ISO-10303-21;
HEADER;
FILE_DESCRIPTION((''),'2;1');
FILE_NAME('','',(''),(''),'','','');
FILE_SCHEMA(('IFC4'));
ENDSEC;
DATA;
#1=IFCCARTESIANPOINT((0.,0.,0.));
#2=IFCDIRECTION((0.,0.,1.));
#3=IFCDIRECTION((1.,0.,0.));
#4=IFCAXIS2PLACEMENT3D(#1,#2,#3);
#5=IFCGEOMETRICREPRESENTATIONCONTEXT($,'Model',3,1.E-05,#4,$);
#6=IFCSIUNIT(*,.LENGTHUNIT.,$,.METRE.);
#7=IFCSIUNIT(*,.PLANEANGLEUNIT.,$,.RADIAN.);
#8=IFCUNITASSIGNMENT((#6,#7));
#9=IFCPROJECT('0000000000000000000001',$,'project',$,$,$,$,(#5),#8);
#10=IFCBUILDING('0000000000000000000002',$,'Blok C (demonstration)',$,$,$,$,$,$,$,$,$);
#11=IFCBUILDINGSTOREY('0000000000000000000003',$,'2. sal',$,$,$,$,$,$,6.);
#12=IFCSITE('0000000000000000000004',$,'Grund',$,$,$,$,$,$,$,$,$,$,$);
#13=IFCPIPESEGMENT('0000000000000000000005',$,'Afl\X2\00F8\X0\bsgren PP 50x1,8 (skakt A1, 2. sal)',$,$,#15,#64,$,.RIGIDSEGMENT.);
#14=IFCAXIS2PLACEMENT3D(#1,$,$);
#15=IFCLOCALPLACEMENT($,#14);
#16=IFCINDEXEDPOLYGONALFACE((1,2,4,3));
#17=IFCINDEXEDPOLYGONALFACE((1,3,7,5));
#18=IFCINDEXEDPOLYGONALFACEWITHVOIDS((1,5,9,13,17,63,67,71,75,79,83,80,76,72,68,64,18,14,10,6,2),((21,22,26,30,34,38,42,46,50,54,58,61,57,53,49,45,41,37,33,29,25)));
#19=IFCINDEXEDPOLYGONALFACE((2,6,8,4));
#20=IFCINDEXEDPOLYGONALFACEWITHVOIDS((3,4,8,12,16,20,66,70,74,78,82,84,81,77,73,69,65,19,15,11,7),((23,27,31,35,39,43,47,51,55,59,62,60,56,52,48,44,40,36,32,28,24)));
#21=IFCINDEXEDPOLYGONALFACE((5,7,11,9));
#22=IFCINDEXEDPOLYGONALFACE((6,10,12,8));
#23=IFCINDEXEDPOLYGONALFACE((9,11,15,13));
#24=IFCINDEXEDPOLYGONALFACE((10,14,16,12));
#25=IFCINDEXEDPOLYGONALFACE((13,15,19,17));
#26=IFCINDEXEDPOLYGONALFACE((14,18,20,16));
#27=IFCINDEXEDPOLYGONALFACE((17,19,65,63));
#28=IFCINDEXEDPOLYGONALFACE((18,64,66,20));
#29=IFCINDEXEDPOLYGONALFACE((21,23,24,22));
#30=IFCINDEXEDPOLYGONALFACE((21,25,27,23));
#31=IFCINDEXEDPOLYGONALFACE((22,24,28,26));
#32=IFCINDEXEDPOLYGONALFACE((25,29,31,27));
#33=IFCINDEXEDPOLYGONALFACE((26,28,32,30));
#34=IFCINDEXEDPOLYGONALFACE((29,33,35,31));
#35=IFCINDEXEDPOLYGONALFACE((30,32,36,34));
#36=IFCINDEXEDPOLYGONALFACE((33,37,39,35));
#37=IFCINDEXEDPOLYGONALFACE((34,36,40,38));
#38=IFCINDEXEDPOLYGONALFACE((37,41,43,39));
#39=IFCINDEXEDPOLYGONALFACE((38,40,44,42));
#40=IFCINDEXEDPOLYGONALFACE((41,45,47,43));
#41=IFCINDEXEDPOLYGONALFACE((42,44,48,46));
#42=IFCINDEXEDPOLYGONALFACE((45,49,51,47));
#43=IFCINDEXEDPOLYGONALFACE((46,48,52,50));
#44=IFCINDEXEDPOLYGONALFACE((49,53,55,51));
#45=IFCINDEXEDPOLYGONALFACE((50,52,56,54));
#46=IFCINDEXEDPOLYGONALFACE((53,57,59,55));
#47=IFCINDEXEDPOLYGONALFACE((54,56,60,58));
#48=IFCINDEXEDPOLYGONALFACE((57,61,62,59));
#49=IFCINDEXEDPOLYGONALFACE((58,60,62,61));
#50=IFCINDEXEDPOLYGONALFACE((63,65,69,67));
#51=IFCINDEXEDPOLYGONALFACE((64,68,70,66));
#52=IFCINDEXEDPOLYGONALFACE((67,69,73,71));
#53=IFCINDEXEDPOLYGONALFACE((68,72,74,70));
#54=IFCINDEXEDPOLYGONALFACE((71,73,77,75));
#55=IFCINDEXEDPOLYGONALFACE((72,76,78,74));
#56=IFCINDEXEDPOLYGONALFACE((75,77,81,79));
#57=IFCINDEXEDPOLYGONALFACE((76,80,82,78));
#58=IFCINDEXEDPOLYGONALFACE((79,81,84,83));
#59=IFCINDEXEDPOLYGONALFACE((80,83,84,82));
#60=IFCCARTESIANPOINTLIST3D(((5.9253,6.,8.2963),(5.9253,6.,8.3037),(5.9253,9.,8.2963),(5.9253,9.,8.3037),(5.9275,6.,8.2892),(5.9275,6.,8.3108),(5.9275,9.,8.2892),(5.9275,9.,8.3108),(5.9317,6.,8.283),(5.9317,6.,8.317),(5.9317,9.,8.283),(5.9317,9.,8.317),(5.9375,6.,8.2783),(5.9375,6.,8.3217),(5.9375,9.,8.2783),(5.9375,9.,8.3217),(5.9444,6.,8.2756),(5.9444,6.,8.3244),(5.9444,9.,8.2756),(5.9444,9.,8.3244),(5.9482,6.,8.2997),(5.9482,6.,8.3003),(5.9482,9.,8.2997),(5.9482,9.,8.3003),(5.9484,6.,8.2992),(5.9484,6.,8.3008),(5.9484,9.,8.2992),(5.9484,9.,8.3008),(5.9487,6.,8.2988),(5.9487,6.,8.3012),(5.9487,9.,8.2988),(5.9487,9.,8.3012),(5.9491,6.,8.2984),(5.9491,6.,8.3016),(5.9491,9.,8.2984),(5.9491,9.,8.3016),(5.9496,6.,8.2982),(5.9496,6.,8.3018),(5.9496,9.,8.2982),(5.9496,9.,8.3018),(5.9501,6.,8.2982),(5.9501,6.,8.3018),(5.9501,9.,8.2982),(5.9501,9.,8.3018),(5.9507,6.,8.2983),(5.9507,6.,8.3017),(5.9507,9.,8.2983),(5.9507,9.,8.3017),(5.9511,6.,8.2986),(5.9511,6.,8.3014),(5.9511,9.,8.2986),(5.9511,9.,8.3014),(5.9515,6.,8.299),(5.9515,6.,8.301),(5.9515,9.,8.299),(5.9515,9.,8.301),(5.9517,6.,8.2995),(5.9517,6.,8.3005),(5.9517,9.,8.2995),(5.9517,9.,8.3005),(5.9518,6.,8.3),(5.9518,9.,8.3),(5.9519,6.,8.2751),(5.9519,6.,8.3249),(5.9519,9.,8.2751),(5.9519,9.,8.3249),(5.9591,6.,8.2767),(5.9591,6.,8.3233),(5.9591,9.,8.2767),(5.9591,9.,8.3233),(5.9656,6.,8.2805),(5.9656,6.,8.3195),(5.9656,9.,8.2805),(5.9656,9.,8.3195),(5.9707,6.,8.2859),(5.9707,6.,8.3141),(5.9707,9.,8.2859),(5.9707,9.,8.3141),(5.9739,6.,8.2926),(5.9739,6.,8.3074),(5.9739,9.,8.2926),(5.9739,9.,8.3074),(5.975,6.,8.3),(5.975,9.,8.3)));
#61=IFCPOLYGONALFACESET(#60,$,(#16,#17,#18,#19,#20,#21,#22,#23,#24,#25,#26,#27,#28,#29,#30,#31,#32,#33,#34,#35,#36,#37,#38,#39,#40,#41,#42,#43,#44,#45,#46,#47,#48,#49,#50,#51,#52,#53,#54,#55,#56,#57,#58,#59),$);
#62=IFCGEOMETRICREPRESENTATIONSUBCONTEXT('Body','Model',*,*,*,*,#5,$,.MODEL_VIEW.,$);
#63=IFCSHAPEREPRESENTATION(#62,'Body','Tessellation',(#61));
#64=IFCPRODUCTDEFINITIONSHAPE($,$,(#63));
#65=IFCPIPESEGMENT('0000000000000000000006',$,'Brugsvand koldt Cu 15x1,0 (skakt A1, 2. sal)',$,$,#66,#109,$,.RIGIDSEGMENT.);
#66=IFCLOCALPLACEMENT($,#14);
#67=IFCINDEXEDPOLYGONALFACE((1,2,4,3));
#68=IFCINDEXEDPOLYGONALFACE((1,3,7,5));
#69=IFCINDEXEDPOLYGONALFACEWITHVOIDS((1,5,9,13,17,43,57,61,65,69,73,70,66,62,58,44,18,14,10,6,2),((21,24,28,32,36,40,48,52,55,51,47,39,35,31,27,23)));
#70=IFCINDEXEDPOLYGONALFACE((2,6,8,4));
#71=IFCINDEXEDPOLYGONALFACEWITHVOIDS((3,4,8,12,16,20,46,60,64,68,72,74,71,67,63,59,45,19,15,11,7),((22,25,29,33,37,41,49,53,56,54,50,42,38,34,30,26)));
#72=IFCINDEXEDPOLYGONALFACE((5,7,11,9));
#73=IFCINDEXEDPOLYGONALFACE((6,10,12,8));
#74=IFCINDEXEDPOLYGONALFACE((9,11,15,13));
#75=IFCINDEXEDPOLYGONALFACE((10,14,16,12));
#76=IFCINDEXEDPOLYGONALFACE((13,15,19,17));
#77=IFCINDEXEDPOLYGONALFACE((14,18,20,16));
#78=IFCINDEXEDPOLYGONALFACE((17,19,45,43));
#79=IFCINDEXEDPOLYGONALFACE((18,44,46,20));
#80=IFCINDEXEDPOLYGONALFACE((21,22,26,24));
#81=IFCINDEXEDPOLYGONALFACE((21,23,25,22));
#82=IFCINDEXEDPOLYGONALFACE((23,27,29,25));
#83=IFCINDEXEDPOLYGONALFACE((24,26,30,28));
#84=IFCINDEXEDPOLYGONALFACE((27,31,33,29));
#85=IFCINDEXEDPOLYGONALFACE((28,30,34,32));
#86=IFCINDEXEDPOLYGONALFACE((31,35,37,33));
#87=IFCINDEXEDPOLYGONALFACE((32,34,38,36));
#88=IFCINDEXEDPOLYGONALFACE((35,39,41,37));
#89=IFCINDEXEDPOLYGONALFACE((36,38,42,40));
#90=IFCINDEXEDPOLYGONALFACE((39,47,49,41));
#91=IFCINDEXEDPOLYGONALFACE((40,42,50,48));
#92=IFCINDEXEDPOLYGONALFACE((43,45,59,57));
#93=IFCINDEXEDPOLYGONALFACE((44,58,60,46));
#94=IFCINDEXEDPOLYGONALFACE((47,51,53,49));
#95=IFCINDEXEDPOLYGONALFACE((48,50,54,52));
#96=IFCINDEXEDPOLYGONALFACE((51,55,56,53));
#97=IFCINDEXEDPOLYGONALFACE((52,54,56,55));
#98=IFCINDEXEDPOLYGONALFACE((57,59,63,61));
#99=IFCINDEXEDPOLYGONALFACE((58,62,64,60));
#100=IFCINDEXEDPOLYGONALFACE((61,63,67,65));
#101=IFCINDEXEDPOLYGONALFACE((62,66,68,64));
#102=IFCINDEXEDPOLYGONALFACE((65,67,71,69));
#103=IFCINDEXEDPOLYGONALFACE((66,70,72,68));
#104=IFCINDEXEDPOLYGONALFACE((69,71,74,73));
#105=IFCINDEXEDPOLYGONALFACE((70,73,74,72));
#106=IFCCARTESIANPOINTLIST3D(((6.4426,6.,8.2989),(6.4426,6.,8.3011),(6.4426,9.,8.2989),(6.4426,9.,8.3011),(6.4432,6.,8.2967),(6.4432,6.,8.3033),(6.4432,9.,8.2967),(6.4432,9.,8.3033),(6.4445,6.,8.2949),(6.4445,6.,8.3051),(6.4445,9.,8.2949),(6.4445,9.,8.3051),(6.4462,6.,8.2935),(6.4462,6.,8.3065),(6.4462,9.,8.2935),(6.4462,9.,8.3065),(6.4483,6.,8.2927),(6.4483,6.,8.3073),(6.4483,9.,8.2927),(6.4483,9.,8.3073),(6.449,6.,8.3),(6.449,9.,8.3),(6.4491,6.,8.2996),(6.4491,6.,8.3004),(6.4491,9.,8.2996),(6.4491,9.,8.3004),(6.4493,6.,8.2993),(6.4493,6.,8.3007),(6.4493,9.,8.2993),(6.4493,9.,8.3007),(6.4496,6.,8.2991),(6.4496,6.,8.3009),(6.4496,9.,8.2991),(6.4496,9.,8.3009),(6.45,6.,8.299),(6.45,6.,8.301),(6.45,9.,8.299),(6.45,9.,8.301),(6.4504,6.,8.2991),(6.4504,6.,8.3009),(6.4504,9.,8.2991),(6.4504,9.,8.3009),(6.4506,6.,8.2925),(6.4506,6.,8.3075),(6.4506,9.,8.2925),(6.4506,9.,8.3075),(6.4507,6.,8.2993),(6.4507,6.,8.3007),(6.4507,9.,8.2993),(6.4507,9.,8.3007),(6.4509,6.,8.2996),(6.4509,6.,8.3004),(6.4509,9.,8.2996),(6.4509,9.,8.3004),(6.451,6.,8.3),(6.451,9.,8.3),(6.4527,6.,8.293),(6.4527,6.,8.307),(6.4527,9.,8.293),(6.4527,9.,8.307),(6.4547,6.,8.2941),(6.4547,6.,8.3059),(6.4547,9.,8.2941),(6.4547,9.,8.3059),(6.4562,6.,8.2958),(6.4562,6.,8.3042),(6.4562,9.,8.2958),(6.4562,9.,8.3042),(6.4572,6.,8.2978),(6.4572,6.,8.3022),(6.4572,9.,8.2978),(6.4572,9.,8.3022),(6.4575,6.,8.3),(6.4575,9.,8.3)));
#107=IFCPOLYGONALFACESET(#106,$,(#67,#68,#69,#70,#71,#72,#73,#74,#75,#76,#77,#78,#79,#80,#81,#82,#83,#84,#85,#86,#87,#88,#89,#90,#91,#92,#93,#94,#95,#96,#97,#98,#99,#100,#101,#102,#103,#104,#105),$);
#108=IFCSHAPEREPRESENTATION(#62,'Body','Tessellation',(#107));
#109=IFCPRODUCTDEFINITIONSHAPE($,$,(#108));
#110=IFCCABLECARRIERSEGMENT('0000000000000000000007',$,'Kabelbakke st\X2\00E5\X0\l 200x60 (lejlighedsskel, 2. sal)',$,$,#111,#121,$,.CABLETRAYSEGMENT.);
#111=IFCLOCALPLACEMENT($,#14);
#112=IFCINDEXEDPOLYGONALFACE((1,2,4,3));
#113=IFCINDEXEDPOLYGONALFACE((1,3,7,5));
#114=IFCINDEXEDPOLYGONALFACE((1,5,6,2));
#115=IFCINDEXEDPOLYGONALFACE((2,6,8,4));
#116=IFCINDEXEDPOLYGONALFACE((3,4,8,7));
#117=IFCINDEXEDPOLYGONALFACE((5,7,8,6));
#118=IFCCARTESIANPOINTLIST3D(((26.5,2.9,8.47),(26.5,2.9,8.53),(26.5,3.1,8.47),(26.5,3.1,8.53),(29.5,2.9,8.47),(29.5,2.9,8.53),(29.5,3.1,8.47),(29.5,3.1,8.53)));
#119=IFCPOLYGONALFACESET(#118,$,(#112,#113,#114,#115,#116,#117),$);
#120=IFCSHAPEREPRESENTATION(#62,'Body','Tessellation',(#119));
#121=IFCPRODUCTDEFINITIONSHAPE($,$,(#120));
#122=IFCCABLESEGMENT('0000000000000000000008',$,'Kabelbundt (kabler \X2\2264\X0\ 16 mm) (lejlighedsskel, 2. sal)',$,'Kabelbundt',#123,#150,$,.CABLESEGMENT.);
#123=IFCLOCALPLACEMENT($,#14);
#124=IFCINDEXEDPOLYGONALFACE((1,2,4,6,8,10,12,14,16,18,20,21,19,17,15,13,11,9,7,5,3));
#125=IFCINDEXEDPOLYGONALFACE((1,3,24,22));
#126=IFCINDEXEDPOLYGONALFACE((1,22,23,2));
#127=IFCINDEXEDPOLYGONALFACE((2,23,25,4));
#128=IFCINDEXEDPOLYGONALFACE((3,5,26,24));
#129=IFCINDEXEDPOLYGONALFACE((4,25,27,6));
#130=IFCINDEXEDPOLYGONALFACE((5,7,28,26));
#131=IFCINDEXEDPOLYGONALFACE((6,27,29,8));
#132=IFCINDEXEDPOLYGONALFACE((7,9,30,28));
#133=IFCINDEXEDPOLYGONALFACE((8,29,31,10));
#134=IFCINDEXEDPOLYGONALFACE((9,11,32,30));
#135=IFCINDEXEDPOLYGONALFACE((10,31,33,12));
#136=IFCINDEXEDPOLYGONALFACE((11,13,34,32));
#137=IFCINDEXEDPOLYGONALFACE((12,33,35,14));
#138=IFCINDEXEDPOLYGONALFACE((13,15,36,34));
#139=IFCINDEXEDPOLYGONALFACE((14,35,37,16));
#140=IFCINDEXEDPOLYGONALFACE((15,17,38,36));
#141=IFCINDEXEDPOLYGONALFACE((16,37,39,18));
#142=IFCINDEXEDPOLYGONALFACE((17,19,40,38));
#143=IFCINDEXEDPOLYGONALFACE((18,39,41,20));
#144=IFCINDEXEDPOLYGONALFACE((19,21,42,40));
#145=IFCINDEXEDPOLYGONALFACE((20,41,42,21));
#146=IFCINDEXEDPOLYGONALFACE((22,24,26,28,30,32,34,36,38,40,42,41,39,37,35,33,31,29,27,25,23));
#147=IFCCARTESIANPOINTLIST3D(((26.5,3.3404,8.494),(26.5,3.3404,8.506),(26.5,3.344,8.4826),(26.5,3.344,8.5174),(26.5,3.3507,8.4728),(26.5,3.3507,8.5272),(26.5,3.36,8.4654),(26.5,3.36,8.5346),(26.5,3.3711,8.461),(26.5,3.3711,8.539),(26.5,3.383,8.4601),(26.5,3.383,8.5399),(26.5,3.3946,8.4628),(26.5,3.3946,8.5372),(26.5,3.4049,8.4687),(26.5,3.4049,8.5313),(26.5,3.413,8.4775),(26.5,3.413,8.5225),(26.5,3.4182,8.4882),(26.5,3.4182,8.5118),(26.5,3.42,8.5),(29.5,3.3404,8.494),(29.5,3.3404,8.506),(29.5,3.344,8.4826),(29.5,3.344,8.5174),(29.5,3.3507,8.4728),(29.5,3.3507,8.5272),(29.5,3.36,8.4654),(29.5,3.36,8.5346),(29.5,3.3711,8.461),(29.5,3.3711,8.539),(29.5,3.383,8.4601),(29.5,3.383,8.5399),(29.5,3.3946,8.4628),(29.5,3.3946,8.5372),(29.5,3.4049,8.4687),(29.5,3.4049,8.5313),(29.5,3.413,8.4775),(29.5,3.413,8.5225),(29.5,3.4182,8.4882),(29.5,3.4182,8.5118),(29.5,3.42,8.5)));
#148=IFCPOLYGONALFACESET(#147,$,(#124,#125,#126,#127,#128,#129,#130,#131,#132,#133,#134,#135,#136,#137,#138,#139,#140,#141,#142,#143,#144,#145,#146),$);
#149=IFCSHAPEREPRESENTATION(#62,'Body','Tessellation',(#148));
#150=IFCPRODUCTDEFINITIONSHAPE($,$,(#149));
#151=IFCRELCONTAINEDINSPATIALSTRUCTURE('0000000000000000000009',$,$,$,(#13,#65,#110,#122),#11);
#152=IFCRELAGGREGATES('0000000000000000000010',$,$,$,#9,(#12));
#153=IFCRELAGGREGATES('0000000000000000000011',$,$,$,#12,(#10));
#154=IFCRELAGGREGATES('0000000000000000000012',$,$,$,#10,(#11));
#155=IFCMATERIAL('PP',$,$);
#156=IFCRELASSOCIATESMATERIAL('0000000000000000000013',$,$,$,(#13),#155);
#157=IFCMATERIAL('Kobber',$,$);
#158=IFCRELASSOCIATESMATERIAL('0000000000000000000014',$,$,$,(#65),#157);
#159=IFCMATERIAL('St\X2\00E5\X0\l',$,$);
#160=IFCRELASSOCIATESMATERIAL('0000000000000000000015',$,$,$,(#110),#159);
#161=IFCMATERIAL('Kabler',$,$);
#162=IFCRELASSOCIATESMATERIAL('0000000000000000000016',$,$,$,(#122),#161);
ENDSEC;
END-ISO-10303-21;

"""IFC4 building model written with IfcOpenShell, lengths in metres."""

from ifc_helpers import new_model, si_unit, frame, origin_with_axes, place, context, subcontext, project, spatial, polyline, circle, hollow_circle, outline, extrude, material, element, save


model = new_model("IFC4")

# Units and contexts
model_context = context("Model", 3, precision=1e-05, world=origin_with_axes())
body_context = subcontext(model_context, "Body", "Model", "MODEL_VIEW")
ifc_project = project(units=[si_unit("LENGTHUNIT", "METRE"), si_unit("PLANEANGLEUNIT", "RADIAN")], contexts=[model_context])

# Site, building, storey
site = spatial("IfcSite", under=ifc_project, Name="Grund")
building = spatial("IfcBuilding", under=site, Name="Blok C (demonstration)")
storey = spatial("IfcBuildingStorey", under=building, Name="2. sal", Elevation=6.0)

# Pipe segments
ifc_material_1 = material(Name="PP")
pipe_segment_1_placement = place(None, origin_with_axes())
element("IfcPipeSegment", 1, at=pipe_segment_1_placement, inside=storey, material=ifc_material_1, Name="Afløbsgren PP 50x1,8 (skakt A1, 2. sal)", PredefinedType="RIGIDSEGMENT", context=body_context, shape_type="SweptSolid", body=[
    extrude(hollow_circle(Radius=0.025, WallThickness=0.0232), frame((5.95, 6.0, 8.3), z_axis=(0.0, 1.0, 0.0), x_axis=(1.0, 0.0, 0.0)), (0.0, 0.0, 1.0), 3.0),
])
ifc_material_2 = material(Name="Kobber")
pipe_segment_2_placement = place(None, origin_with_axes())
element("IfcPipeSegment", 2, at=pipe_segment_2_placement, inside=storey, material=ifc_material_2, Name="Brugsvand koldt Cu 15x1,0 (skakt A1, 2. sal)", PredefinedType="RIGIDSEGMENT", context=body_context, shape_type="SweptSolid", body=[
    extrude(hollow_circle(Radius=0.0075, WallThickness=0.0065), frame((6.45, 6.0, 8.3), z_axis=(0.0, 1.0, 0.0), x_axis=(1.0, 0.0, 0.0)), (0.0, 0.0, 1.0), 3.0),
])

# Cable carrier segment
ifc_material_3 = material(Name="Stål")
cable_carrier_segment_placement = place(None, origin_with_axes())
element("IfcCableCarrierSegment", 3, at=cable_carrier_segment_placement, inside=storey, material=ifc_material_3, Name="Kabelbakke stål 200x60 (lejlighedsskel, 2. sal)", PredefinedType="CABLETRAYSEGMENT", context=body_context, shape_type="SweptSolid", body=[
    extrude(outline(polyline([(26.5, 2.9), (29.5, 2.9), (29.5, 3.1), (26.5, 3.1), (26.5, 2.9)])), frame((0.0, 0.0, 8.47)), (0.0, 0.0, 1.0), 0.06),
])

# Cable segment
ifc_material_4 = material(Name="Kabler")
cable_segment_placement = place(None, origin_with_axes())
element("IfcCableSegment", 4, at=cable_segment_placement, inside=storey, material=ifc_material_4, Name="Kabelbundt (kabler ≤ 16 mm) (lejlighedsskel, 2. sal)", ObjectType="Kabelbundt", PredefinedType="CABLESEGMENT", context=body_context, shape_type="SweptSolid", body=[
    extrude(circle(Radius=0.04), frame((26.5, 3.38, 8.5), z_axis=(1.0, 0.0, 0.0), x_axis=(0.0, 1.0, 0.0)), (0.0, 0.0, 1.0), 3.0),
])

save(model, "model.ifc")
